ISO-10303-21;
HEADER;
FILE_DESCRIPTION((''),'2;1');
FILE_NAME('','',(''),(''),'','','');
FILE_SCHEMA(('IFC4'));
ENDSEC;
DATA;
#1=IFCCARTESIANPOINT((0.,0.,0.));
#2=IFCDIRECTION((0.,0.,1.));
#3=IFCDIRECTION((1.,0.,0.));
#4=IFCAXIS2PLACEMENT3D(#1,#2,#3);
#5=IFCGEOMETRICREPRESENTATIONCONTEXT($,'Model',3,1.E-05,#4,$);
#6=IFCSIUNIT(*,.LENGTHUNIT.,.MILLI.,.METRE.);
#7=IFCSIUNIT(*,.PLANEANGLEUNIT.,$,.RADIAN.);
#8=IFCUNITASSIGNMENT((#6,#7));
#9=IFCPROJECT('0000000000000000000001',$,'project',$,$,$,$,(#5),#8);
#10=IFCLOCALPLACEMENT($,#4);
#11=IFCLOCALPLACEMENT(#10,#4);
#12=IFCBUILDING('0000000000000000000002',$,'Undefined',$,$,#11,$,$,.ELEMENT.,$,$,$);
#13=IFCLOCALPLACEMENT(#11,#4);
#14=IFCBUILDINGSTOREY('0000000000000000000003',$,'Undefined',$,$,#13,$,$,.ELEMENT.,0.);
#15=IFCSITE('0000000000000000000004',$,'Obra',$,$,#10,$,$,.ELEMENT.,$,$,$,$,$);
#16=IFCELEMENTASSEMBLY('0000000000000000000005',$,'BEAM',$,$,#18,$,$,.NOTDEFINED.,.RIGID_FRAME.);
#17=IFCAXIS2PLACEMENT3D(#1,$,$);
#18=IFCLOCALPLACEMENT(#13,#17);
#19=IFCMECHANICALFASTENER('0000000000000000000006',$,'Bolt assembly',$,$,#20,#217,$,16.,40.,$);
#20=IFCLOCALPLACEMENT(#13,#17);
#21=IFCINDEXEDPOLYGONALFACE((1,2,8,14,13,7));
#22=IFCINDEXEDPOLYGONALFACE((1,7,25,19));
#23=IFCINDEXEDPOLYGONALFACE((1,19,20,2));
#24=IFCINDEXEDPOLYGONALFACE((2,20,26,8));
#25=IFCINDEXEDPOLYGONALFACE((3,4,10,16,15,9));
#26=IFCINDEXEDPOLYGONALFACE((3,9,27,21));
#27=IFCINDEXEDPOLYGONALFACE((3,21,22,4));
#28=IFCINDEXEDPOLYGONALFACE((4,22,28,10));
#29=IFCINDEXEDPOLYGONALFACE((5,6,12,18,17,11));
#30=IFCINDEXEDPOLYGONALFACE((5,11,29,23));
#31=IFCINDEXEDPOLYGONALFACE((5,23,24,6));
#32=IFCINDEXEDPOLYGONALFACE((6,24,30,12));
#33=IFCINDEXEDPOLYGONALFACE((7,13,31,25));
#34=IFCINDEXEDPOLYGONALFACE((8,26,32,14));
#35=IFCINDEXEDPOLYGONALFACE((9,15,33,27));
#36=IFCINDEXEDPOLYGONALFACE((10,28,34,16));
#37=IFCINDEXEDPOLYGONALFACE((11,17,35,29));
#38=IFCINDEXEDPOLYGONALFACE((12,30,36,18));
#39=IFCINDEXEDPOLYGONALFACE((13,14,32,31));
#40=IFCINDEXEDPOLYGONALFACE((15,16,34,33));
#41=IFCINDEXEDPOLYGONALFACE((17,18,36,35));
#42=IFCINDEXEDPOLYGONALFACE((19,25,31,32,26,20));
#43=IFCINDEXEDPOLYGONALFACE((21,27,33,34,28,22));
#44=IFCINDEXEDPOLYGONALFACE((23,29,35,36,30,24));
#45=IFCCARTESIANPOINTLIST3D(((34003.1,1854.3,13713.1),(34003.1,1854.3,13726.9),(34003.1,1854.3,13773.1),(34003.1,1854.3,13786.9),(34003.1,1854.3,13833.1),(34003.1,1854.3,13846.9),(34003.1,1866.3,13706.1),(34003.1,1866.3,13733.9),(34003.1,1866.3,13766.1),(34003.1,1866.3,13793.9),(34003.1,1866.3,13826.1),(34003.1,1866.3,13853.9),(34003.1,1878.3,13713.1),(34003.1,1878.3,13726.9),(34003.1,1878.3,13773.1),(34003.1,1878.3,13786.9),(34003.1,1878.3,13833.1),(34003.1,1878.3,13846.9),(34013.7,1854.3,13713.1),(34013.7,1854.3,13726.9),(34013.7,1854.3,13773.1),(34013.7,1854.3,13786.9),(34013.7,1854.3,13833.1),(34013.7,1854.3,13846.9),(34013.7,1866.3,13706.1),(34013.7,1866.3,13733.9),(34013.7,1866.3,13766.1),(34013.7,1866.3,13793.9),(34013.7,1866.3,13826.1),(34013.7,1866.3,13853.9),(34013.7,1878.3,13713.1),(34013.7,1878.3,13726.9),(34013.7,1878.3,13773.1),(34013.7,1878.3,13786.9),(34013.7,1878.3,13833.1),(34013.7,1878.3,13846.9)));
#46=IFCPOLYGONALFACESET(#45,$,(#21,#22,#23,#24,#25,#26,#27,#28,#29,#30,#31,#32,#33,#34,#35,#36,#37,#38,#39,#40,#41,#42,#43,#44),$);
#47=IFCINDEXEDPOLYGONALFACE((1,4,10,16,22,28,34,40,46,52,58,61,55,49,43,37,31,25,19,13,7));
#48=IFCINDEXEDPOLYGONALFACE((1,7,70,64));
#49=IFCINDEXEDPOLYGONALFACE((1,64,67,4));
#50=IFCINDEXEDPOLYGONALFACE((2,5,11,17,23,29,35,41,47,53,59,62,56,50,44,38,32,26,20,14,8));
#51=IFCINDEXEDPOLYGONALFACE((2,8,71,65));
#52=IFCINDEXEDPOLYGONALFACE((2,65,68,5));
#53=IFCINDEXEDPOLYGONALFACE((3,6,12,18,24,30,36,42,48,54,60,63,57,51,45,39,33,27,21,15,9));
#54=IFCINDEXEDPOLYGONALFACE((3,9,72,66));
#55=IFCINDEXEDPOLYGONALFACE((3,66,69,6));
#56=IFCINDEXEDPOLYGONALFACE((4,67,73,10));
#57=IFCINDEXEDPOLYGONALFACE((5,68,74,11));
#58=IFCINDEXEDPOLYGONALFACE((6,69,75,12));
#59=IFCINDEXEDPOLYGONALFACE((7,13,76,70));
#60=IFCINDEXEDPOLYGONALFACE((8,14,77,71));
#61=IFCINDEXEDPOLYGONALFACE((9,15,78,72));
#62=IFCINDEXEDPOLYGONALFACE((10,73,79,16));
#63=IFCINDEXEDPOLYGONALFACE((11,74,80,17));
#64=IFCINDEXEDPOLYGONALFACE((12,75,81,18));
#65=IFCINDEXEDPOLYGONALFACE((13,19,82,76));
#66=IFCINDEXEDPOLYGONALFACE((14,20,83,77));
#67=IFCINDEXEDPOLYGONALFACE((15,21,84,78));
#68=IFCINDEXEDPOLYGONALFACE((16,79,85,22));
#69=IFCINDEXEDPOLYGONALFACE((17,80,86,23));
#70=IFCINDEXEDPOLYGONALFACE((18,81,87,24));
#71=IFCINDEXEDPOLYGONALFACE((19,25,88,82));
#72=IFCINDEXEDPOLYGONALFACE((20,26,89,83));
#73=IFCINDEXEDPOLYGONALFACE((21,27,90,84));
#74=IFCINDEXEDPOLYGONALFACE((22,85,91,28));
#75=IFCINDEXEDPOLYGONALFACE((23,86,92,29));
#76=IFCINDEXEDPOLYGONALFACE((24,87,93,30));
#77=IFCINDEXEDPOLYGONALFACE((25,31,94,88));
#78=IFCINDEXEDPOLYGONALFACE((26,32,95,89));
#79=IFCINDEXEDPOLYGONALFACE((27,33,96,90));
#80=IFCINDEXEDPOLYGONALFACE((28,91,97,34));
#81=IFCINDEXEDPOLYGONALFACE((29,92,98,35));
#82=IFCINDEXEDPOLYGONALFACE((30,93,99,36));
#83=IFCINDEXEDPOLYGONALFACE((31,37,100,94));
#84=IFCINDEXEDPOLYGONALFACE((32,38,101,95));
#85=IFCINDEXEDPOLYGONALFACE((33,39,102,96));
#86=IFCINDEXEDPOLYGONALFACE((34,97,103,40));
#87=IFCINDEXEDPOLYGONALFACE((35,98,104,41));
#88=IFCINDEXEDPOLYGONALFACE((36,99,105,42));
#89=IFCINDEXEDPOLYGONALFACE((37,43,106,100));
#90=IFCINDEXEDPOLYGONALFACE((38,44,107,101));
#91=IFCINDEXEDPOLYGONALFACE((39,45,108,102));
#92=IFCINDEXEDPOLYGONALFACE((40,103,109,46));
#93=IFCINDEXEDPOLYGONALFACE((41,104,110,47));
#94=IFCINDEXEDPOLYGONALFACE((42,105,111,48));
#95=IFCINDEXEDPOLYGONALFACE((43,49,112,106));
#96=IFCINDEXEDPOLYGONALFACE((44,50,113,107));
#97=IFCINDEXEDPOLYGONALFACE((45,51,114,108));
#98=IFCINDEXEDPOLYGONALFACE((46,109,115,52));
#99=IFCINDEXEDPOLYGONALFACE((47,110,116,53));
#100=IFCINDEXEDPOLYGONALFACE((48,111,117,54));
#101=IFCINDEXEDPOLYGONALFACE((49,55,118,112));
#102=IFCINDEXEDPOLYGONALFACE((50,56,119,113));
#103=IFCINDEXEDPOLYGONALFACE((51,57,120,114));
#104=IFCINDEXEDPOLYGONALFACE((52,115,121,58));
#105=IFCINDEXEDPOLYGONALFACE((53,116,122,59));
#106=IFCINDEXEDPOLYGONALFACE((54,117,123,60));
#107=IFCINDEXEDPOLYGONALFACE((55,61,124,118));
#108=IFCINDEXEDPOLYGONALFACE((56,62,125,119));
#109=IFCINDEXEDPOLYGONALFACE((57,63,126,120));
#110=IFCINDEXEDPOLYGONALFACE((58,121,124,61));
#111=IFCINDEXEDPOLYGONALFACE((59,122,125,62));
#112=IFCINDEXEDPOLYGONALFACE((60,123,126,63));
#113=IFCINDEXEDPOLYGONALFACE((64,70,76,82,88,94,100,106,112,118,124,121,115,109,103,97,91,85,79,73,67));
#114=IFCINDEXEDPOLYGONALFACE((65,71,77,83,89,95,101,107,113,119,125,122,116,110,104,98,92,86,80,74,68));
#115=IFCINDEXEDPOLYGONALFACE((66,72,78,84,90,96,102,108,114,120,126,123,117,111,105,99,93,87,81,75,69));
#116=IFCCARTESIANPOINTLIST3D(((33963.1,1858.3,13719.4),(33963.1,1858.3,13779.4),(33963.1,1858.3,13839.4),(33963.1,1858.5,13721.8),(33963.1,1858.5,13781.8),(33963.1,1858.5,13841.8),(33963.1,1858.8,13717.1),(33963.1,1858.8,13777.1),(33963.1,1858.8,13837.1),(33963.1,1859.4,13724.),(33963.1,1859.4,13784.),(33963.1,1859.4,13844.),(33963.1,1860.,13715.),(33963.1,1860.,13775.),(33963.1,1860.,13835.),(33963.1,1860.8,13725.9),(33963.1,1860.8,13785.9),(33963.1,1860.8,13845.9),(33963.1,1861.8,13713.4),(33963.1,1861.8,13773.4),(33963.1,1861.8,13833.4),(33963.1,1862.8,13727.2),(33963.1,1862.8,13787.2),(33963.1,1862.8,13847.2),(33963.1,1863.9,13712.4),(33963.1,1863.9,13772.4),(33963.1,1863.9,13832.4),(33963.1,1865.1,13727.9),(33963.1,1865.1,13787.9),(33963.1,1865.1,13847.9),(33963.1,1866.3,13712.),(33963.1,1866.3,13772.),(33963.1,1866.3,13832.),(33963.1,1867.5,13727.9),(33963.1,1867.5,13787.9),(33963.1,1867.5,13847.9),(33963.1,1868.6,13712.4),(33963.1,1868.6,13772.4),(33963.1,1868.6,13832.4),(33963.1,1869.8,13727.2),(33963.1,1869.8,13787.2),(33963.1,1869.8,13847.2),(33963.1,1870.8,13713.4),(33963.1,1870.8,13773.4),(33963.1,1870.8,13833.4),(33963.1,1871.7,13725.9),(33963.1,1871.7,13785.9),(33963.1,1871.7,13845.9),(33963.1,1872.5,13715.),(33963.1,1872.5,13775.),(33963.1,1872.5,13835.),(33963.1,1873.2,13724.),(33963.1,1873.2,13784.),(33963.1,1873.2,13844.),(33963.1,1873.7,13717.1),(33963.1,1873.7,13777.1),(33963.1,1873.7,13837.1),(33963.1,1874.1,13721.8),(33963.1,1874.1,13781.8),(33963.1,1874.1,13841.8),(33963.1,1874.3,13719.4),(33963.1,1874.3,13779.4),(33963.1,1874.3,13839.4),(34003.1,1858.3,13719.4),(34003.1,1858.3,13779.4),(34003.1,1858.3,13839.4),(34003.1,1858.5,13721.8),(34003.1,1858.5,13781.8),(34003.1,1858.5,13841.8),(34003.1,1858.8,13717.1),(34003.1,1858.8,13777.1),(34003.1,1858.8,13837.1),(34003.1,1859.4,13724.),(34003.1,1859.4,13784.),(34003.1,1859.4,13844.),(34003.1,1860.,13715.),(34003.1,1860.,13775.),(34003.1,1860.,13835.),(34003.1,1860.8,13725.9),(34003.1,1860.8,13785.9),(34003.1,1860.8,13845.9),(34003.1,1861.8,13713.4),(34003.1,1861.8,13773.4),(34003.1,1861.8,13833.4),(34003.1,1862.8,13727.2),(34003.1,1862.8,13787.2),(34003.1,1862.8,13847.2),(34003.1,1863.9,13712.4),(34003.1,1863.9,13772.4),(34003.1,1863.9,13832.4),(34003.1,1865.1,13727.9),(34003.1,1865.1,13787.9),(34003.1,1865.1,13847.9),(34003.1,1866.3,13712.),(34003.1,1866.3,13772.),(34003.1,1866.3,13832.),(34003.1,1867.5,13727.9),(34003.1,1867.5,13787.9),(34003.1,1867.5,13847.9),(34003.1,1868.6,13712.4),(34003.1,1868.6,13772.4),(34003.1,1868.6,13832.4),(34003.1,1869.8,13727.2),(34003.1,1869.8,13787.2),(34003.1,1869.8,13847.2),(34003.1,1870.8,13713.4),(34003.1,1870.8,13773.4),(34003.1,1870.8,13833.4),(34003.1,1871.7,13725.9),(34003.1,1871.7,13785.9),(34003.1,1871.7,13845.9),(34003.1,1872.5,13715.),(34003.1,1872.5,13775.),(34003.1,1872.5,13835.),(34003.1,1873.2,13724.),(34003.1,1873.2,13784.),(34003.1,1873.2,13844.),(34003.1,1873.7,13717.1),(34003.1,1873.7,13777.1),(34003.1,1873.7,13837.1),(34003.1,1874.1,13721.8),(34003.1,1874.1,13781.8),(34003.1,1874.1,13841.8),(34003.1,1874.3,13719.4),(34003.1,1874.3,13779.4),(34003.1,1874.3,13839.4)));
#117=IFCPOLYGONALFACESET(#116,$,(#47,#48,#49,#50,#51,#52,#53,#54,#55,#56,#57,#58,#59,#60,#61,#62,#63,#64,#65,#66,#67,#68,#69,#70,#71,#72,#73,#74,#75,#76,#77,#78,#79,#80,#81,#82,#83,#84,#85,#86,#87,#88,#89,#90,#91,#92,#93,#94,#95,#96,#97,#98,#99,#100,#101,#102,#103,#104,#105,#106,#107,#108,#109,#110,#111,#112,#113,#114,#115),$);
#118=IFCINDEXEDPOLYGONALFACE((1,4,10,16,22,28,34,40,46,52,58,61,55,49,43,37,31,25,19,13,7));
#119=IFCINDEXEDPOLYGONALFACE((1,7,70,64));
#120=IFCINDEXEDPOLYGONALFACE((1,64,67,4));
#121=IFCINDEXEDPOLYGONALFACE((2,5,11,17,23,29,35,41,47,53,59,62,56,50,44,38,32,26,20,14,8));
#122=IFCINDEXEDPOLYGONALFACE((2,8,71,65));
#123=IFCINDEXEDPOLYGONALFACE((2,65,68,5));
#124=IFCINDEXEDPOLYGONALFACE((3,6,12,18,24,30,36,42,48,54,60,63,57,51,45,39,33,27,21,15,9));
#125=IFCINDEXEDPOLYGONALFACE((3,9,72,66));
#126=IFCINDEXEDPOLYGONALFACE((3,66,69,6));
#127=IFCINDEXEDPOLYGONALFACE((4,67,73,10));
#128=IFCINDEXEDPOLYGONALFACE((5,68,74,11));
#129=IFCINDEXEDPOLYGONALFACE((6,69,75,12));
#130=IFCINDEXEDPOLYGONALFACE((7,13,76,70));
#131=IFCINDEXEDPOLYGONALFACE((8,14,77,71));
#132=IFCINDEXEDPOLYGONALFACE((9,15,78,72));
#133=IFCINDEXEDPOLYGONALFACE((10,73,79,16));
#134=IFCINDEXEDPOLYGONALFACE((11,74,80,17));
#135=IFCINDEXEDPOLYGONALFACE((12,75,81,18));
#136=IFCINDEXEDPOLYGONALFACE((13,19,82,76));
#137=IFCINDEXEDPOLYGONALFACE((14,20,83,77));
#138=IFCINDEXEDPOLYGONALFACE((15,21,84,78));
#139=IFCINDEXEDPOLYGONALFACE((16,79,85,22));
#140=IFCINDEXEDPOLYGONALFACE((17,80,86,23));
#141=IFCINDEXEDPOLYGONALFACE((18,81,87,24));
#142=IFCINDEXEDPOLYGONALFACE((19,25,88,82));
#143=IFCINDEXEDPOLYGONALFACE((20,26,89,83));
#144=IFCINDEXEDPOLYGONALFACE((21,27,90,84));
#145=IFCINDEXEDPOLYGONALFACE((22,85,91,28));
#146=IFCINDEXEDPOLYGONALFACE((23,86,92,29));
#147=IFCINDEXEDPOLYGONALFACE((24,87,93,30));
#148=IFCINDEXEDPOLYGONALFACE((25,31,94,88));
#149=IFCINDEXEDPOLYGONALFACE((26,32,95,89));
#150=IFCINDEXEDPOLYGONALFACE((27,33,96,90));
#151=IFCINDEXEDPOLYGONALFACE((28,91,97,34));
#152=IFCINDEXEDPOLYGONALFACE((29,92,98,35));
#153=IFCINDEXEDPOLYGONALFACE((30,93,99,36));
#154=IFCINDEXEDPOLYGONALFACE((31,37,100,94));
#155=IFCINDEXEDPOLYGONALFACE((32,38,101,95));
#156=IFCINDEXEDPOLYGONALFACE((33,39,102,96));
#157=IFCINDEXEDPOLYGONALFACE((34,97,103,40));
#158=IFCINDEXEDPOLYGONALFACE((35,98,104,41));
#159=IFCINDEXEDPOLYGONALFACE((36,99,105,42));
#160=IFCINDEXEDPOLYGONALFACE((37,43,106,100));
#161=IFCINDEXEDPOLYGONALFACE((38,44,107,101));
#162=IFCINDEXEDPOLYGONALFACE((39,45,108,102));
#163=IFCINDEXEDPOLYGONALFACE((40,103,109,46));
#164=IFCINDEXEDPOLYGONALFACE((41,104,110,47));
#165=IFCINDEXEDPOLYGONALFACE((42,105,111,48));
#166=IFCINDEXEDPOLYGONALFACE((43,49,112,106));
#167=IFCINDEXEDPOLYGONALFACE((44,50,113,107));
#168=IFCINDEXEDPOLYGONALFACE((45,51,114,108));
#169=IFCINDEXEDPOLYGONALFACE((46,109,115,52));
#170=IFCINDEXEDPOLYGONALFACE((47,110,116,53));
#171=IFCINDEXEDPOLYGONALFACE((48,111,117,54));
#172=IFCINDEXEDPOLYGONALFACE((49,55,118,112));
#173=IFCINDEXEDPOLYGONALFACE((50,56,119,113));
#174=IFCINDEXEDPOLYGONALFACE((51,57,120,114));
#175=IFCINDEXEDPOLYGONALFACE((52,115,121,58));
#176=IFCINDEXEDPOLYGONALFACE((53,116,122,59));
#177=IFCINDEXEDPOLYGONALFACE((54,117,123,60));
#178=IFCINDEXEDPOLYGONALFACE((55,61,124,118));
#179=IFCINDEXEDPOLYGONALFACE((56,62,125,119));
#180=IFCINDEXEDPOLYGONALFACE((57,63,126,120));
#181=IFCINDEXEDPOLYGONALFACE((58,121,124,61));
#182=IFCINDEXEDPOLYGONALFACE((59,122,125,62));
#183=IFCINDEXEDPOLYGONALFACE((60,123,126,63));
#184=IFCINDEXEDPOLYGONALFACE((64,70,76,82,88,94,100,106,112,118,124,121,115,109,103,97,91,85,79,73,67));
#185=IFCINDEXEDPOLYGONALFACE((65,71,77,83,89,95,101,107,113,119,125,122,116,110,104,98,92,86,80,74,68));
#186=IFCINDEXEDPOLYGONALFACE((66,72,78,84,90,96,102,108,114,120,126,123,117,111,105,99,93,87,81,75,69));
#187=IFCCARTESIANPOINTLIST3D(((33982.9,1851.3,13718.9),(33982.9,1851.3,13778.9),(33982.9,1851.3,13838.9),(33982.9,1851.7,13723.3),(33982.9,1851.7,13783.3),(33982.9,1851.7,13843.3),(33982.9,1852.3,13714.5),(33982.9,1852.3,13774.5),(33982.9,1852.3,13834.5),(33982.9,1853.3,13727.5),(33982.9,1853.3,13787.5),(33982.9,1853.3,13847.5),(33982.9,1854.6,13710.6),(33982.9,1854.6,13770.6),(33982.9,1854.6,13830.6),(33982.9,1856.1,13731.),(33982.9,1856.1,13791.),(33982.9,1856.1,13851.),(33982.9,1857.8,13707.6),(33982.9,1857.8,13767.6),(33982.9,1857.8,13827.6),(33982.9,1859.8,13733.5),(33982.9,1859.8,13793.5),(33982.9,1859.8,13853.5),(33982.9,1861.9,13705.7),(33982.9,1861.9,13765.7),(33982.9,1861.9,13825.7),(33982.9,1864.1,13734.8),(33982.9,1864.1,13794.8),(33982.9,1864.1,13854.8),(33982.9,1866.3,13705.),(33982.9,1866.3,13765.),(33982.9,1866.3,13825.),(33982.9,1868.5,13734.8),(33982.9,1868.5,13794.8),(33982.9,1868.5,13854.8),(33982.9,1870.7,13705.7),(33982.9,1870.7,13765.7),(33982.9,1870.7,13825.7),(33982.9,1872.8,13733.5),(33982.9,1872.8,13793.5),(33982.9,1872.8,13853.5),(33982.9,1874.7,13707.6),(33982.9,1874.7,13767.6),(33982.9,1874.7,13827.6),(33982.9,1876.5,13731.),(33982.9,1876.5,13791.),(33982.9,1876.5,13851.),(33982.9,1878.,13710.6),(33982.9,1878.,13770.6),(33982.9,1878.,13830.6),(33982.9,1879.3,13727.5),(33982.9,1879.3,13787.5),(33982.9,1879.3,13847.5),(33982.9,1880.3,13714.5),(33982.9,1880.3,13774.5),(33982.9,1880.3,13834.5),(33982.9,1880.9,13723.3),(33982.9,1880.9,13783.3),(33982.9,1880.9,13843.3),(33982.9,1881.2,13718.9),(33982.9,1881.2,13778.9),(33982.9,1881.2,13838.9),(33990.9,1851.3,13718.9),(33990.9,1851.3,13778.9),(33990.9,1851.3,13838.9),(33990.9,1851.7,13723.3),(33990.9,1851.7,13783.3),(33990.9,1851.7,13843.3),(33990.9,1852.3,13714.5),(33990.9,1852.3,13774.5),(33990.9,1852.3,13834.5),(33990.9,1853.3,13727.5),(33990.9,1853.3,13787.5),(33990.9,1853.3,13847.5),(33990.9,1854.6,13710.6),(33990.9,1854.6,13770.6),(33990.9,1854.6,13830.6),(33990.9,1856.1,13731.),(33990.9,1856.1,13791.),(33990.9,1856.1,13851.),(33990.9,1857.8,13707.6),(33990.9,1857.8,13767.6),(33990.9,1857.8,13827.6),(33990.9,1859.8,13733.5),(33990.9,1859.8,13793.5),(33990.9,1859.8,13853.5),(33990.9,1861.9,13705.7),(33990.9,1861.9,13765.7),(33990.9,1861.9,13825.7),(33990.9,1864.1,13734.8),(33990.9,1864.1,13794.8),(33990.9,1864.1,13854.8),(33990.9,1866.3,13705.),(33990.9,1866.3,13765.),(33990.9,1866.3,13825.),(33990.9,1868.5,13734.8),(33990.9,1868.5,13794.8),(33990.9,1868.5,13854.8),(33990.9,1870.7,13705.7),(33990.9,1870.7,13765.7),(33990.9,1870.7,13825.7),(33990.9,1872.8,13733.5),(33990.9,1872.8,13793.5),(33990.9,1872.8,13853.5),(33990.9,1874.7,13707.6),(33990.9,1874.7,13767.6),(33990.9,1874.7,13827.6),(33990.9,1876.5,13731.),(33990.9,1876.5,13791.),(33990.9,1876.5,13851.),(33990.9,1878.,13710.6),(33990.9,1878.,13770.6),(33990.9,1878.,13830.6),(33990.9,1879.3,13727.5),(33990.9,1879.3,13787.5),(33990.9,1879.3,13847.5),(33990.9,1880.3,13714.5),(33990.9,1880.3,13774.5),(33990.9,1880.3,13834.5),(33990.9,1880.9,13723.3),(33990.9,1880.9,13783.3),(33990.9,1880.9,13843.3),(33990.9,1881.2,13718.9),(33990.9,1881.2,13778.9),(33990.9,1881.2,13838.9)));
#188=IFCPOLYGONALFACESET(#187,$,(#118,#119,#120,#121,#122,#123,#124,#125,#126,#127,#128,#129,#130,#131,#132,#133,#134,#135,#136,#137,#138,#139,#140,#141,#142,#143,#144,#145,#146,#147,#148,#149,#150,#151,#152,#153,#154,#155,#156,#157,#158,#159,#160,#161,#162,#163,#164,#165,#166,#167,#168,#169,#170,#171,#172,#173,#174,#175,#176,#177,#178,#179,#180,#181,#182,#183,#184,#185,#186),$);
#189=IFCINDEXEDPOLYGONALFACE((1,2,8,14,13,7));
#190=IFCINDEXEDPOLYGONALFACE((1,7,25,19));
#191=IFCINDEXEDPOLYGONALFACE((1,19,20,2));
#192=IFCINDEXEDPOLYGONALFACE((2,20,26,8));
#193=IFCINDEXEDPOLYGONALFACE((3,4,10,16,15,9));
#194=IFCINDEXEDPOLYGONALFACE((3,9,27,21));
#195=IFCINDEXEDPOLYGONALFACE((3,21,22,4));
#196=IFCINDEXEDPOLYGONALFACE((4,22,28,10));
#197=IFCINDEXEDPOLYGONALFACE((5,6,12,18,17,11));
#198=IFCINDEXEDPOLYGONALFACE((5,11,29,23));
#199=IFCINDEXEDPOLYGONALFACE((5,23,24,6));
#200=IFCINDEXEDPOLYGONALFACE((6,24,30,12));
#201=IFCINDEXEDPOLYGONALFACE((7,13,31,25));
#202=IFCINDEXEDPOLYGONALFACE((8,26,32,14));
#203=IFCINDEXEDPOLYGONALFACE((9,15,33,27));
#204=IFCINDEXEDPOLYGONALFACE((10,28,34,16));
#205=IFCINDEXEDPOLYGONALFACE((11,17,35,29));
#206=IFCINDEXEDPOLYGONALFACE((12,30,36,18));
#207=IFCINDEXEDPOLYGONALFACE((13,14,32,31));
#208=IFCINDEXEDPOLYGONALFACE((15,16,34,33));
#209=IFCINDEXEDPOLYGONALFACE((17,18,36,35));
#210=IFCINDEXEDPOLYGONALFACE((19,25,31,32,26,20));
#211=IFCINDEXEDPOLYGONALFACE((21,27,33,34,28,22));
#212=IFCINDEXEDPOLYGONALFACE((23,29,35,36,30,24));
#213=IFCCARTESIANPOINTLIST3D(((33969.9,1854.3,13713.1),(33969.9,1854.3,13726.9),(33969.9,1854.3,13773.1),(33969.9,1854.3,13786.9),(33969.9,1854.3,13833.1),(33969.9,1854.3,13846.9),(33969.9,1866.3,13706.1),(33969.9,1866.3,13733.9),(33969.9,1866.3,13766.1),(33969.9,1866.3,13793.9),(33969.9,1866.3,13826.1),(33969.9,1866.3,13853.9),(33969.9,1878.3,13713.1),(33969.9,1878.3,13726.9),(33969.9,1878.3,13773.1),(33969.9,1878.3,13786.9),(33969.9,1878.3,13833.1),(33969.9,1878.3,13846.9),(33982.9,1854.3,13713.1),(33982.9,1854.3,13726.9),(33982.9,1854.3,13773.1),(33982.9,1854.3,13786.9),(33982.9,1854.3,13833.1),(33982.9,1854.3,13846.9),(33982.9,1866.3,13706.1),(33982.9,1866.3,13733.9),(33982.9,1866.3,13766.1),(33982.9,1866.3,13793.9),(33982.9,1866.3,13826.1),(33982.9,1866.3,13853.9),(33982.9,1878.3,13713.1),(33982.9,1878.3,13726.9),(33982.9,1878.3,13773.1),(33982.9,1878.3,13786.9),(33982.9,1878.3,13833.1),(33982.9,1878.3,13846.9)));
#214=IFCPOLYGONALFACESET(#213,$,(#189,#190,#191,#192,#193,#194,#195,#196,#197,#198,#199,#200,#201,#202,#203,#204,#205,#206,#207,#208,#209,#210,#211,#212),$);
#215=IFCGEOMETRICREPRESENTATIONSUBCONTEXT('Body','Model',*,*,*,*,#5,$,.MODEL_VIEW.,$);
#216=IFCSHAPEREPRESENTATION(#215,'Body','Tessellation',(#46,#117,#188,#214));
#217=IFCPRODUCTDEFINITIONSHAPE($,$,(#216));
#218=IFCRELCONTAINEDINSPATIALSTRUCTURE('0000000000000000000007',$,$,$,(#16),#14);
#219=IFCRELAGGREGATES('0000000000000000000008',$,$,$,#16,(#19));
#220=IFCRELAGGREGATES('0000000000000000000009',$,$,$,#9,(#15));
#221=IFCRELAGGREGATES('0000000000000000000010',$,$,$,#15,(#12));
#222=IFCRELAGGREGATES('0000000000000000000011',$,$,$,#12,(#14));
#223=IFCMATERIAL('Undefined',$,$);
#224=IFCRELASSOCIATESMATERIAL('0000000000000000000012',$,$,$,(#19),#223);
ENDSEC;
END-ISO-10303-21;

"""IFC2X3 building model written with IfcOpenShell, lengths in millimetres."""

from ifc_helpers import new_model, si_unit, frame, origin_with_axes, origin_2d_with_axis, place, context, subcontext, project, spatial, polyline, circle, outline, extrude, source, transform, mapped, material, element, aggregate, save


model = new_model("IFC2X3")

# Units and contexts
model_context = context("Model", 3, precision=1e-05, world=origin_with_axes())
body_context = subcontext(model_context, "Body", "Model", "MODEL_VIEW")
ifc_project = project(units=[si_unit("LENGTHUNIT", "METRE", prefix="MILLI"), si_unit("PLANEANGLEUNIT", "RADIAN")], contexts=[model_context])

# Site, building, storey
site_placement = place(None, origin_with_axes())
site = spatial("IfcSite", under=ifc_project, at=site_placement, Name="Obra", CompositionType="ELEMENT")
building_placement = place(site_placement, origin_with_axes())
building = spatial("IfcBuilding", under=site, at=building_placement, Name="Undefined", CompositionType="ELEMENT")
storey_placement = place(building_placement, origin_with_axes())
storey = spatial("IfcBuildingStorey", under=building, at=storey_placement, Name="Undefined", CompositionType="ELEMENT", Elevation=0.0)

# Shared definitions
ifc_material_1 = material(Name="Undefined")

# Element assembly, mechanical fastener
shared_shape_1 = source(origin_with_axes(), body_context, "Body", "SweptSolid", [
    extrude(outline(polyline([(13.9, 0.0), (6.9, 12.0), (-6.9, 12.0), (-13.9, 0.0), (-6.9, -12.0), (6.9, -12.0), (13.9, 0.0)])), frame((0.0, -13.7, 0.0), z_axis=(0.0, 1.0, 0.0), x_axis=(1.0, 0.0, 0.0)), (0.0, 0.0, 1.0), 10.6),
    extrude(circle(Radius=8.0, at=origin_2d_with_axis()), frame((0.0, -3.1, 0.0), z_axis=(0.0, 1.0, 0.0), x_axis=(1.0, 0.0, 0.0)), (0.0, 0.0, 1.0), 40.0),
    extrude(circle(Radius=15.0, at=origin_2d_with_axis()), frame((0.0, 9.1, 0.0), z_axis=(0.0, 1.0, 0.0), x_axis=(1.0, 0.0, 0.0)), (0.0, 0.0, 1.0), 8.0),
    extrude(outline(polyline([(13.9, 0.0), (6.9, 12.0), (-6.9, 12.0), (-13.9, 0.0), (-6.9, -12.0), (6.9, -12.0), (13.9, 0.0)])), frame((0.0, 17.1, 0.0), z_axis=(0.0, 1.0, 0.0), x_axis=(1.0, 0.0, 0.0)), (0.0, 0.0, 1.0), 13.0),
])
assembly_1_placement = place(storey_placement, origin_with_axes())
assembly_1 = element("IfcElementAssembly", 1, at=assembly_1_placement, inside=storey, Name="BEAM", AssemblyPlace="NOTDEFINED", PredefinedType="RIGID_FRAME")
mechanical_fastener_1_placement = place(assembly_1_placement, frame((34000.0, 1816.3, 13900.0), z_axis=(0.0, 1.0, 0.0), x_axis=(0.0, 0.0, -1.0)))
mechanical_fastener_1 = element("IfcMechanicalFastener", 2, at=mechanical_fastener_1_placement, material=ifc_material_1, Name="Bolt assembly", NominalDiameter=16.0, NominalLength=40.0, context=body_context, shape_type="MappedRepresentation", body=[
    mapped(shared_shape_1, transform((60.0, 0.0, 50.0))),
    mapped(shared_shape_1, transform((120.0, 0.0, 50.0))),
    mapped(shared_shape_1, transform((180.0, 0.0, 50.0))),
])

aggregate(assembly_1, [mechanical_fastener_1])

save(model, "model.ifc")
